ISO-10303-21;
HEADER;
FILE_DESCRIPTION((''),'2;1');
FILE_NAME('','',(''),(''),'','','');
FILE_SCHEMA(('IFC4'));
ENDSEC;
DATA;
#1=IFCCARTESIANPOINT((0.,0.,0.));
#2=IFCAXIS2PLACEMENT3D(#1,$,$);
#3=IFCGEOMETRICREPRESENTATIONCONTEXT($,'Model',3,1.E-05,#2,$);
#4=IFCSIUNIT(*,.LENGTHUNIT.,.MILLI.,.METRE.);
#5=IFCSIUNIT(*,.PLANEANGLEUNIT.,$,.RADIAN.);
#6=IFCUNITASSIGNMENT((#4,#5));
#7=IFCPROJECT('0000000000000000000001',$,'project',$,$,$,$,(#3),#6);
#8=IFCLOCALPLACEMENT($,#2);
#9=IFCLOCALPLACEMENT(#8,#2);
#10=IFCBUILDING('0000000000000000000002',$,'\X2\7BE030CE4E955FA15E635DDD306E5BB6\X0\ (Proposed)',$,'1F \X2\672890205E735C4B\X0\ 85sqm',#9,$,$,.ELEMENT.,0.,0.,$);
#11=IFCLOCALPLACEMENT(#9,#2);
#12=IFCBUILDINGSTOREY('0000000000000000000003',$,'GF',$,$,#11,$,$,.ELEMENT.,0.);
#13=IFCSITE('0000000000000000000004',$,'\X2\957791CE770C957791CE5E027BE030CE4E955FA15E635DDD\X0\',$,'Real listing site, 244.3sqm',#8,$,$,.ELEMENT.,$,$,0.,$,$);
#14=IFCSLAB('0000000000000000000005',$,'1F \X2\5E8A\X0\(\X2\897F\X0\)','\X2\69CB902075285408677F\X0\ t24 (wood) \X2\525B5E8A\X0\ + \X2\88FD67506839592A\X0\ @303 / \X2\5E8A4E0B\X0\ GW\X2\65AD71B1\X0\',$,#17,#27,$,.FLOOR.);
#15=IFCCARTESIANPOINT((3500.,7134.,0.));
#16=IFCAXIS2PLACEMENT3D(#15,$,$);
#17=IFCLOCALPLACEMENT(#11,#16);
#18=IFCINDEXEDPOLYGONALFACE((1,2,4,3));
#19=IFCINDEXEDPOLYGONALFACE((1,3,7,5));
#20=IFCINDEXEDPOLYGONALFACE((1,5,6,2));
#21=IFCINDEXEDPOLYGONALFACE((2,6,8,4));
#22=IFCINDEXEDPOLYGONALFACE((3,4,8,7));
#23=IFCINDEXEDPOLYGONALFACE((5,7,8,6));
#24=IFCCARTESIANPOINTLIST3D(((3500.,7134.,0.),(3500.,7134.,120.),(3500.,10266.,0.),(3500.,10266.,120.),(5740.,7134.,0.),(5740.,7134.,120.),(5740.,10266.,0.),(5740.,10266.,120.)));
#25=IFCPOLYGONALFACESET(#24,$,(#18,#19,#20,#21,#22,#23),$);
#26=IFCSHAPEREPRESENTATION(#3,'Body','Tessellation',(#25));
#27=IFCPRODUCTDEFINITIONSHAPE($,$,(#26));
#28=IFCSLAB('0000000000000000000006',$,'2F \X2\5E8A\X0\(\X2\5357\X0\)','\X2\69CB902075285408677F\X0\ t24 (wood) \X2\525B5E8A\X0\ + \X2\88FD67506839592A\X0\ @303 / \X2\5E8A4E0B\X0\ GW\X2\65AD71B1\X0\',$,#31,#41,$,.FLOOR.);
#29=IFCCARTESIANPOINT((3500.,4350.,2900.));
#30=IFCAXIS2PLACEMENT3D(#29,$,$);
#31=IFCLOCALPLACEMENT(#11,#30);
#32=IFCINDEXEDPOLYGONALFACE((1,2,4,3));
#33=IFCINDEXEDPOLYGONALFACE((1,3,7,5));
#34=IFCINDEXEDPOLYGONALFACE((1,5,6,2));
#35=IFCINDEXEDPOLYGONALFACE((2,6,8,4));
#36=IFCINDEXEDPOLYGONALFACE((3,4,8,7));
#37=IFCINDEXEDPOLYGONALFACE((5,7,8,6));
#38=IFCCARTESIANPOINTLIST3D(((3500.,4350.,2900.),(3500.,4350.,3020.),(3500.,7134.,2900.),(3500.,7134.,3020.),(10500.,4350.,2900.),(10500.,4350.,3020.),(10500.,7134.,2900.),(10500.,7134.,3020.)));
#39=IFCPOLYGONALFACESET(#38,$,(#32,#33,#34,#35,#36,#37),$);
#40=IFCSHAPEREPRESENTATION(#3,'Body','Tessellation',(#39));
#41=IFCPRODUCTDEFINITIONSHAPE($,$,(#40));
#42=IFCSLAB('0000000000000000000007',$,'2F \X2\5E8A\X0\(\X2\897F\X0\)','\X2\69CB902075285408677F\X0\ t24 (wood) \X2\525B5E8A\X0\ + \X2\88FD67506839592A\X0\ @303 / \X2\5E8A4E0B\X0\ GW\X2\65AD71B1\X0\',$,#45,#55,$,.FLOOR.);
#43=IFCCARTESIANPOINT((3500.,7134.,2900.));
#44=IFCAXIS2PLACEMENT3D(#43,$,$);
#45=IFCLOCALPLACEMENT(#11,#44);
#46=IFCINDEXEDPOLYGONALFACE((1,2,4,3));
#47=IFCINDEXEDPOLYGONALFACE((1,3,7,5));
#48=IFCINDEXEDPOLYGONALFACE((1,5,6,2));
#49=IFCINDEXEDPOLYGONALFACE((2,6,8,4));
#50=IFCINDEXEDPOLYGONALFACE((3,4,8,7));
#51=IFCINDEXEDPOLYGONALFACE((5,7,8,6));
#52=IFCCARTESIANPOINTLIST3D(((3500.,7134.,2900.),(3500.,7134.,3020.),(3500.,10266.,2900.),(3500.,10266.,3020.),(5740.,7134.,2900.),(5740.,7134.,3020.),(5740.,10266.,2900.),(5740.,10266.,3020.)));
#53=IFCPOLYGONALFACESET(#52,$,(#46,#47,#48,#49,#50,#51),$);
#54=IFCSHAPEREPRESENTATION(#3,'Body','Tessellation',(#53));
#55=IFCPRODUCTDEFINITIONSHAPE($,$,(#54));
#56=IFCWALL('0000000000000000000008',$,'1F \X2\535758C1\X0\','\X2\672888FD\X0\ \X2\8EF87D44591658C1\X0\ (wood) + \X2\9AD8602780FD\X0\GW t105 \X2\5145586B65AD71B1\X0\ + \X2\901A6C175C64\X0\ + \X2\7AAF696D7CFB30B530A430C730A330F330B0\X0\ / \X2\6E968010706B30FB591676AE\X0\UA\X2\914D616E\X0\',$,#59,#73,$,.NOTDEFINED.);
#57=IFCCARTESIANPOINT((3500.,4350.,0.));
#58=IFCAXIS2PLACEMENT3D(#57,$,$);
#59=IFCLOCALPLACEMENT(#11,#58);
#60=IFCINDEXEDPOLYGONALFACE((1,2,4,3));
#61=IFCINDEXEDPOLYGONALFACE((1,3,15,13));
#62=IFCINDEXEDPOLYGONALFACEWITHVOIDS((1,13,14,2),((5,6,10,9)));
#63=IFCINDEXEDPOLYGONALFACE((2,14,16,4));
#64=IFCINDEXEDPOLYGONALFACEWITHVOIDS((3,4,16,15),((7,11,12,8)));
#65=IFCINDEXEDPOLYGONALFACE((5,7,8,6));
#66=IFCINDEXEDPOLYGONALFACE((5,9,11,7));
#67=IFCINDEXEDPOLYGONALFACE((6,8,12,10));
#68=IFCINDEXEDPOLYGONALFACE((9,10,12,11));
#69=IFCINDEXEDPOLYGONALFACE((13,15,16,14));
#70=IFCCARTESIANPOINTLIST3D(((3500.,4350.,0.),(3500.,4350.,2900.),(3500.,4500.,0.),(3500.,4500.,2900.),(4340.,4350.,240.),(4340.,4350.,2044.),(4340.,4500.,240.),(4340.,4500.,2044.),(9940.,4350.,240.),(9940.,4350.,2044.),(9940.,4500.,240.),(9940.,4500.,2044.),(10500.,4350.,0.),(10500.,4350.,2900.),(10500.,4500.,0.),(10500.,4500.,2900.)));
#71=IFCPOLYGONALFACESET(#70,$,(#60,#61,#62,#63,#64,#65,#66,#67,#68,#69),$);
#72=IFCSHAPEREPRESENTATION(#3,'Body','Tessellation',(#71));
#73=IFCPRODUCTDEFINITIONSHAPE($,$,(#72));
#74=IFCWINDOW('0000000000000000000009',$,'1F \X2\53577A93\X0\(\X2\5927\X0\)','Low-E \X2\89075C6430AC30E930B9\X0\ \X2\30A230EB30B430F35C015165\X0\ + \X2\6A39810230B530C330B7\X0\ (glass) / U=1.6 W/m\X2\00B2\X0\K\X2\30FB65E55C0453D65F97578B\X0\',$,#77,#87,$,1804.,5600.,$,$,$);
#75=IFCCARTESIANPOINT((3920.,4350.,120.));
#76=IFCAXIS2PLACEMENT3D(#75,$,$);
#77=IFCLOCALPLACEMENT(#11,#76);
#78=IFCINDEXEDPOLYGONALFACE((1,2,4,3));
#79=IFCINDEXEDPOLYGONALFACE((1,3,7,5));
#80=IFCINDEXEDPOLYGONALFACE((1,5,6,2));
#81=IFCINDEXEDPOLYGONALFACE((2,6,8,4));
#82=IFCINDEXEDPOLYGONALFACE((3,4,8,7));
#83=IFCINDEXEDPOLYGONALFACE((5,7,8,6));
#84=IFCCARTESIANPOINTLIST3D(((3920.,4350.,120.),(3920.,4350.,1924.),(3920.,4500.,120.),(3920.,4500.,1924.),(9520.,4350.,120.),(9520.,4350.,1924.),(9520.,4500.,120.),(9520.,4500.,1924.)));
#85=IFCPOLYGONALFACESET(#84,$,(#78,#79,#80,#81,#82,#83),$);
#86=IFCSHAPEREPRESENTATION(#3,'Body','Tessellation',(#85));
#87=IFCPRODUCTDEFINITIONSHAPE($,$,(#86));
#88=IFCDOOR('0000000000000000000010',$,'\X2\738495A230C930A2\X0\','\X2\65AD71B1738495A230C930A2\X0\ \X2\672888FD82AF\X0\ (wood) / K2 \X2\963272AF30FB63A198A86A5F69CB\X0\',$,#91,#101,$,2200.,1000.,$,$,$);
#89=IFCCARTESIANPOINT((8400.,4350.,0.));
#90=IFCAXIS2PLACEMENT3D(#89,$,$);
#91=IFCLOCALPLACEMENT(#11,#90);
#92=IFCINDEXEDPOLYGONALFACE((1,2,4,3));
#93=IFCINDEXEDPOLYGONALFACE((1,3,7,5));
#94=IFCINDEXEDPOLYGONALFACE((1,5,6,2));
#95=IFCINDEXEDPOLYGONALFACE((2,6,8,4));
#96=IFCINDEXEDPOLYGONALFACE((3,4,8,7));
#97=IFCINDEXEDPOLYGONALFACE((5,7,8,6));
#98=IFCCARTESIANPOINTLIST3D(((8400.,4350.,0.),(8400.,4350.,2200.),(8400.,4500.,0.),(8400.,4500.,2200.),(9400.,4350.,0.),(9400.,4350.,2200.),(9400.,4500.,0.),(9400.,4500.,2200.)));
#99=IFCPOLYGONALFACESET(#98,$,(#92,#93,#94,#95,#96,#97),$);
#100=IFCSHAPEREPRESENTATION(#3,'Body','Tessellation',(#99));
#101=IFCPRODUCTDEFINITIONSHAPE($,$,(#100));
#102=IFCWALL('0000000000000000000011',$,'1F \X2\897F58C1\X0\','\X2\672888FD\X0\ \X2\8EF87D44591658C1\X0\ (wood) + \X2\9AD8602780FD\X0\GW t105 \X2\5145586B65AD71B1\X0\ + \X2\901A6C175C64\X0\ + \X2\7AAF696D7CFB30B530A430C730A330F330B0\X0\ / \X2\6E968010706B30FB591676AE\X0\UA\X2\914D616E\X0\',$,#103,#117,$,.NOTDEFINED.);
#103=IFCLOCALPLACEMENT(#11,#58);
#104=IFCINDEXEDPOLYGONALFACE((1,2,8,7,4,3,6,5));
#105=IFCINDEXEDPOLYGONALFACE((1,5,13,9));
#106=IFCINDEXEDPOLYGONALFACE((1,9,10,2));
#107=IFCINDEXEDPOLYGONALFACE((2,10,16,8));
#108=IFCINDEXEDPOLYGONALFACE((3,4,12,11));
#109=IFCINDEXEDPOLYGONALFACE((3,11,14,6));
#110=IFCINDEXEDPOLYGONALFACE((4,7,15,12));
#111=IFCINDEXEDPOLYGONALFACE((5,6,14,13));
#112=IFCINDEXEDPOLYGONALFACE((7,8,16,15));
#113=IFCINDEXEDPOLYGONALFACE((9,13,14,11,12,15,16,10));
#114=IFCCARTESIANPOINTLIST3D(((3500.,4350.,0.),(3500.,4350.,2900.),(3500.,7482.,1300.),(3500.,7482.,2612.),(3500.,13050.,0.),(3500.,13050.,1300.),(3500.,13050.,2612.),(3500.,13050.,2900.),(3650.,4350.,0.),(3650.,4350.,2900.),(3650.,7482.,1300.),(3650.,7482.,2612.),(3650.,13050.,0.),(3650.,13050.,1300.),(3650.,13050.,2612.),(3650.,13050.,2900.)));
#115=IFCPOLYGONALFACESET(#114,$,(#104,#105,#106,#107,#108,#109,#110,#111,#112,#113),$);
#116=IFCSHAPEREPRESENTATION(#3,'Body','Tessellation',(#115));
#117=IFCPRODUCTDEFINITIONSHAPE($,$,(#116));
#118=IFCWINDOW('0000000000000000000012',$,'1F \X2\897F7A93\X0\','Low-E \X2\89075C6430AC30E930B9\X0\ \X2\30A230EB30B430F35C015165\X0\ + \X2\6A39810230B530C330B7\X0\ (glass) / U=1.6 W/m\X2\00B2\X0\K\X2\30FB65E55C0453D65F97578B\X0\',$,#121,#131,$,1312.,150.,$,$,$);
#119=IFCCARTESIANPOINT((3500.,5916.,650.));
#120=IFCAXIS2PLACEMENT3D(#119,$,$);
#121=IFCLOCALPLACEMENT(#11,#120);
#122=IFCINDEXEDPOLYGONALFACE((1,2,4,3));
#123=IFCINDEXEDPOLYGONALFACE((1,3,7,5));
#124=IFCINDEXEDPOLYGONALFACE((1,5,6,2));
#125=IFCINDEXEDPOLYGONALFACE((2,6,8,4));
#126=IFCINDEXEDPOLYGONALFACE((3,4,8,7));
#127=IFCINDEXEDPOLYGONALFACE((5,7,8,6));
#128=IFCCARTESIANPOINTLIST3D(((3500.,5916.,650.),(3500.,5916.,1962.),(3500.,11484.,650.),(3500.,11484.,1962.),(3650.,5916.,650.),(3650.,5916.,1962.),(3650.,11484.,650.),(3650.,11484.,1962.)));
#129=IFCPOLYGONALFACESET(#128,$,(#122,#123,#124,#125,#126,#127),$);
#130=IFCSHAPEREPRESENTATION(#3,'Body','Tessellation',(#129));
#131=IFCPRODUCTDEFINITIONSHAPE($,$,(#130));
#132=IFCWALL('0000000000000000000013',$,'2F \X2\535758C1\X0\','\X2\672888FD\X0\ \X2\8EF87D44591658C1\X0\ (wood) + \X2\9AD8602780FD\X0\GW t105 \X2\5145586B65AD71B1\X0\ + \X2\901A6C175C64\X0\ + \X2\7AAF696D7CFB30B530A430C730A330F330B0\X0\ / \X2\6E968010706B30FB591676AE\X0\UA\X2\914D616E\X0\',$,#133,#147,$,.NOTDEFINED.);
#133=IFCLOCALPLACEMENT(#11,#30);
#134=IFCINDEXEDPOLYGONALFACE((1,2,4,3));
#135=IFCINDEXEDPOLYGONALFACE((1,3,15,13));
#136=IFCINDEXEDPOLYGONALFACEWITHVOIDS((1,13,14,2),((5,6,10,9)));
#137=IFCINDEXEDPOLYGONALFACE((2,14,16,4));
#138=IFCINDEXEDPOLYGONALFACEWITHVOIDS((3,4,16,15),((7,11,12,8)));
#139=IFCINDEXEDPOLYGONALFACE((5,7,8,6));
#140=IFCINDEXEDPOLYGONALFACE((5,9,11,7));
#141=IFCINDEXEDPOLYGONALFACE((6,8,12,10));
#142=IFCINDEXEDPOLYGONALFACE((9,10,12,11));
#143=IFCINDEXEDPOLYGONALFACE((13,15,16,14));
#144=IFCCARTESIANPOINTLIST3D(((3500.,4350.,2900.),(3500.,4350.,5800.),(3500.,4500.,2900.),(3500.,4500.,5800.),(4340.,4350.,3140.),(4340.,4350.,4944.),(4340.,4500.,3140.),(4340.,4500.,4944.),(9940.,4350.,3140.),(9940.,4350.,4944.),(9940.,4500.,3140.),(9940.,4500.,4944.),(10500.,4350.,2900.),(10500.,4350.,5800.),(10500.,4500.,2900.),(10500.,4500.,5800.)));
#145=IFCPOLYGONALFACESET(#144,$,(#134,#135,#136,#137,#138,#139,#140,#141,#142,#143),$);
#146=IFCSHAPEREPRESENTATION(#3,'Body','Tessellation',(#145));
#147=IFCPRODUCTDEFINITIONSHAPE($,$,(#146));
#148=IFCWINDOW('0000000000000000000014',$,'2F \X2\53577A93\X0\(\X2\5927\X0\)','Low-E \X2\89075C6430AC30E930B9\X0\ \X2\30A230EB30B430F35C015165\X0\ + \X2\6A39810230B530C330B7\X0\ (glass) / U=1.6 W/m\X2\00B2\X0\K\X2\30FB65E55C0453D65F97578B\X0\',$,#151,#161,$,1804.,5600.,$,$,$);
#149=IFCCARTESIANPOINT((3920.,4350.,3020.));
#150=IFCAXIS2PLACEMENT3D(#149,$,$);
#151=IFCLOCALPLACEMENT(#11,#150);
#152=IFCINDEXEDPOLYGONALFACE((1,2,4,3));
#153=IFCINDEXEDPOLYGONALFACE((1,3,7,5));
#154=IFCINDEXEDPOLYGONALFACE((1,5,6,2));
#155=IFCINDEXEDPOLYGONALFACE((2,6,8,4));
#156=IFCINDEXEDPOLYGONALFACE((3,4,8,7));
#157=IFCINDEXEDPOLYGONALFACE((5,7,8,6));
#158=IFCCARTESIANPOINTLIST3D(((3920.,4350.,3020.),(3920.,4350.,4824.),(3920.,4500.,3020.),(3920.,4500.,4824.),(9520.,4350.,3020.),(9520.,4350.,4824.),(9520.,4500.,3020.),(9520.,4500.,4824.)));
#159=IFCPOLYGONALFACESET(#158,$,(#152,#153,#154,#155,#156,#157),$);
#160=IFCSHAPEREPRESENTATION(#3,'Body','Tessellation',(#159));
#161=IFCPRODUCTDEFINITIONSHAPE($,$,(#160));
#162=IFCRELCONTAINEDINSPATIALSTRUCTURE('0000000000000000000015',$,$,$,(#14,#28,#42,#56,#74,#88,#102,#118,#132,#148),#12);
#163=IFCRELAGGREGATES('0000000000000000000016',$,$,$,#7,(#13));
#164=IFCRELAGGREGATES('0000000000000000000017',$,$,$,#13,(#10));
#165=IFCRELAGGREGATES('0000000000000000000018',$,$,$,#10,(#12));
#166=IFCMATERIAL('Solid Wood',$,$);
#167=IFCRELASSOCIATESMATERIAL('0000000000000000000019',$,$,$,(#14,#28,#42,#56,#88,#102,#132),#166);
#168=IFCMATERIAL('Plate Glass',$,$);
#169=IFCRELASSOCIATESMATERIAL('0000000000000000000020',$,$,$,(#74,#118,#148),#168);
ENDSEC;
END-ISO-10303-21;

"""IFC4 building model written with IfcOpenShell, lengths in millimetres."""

from ifc_helpers import new_model, si_unit, frame, frame_2d, origin, place, context, project, spatial, rectangle, extrude, material, element, fill, save


model = new_model("IFC4")

# Units and contexts
model_context = context("Model", 3, precision=1e-05, world=origin())
ifc_project = project(units=[si_unit("LENGTHUNIT", "METRE", prefix="MILLI"), si_unit("PLANEANGLEUNIT", "RADIAN")], contexts=[model_context])

# Site, building, storey
site_placement = place(None, origin())
site = spatial("IfcSite", under=ifc_project, at=site_placement, Name="長野県長野市篠ノ井御幣川", ObjectType="Real listing site, 244.3sqm", CompositionType="ELEMENT", RefElevation=0.0)
building_placement = place(site_placement, origin())
building = spatial("IfcBuilding", under=site, at=building_placement, Name="篠ノ井御幣川の家 (Proposed)", ObjectType="1F 木造平屋 85sqm", CompositionType="ELEMENT", ElevationOfRefHeight=0.0, ElevationOfTerrain=0.0)
storey_placement = place(building_placement, origin())
storey = spatial("IfcBuildingStorey", under=building, at=storey_placement, Name="GF", CompositionType="ELEMENT", Elevation=0.0)

# Slabs
ifc_material_1 = material(Name="Solid Wood")
slab_1_placement = place(storey_placement, frame((3500.0, 7134.0, 0.0)))
element("IfcSlab", 1, at=slab_1_placement, inside=storey, material=ifc_material_1, Name="1F 床(西)", Description="構造用合板 t24 (wood) 剛床 + 製材根太 @303 / 床下 GW断熱", PredefinedType="FLOOR", context=model_context, shape_type="SweptSolid", body=[
    extrude(rectangle(XDim=2240.0, YDim=3132.0, at=frame_2d((1120.0, 1566.0))), frame((3500.0, 7134.0, 0.0)), (0.0, 0.0, 1.0), 120.0),
])
slab_2_placement = place(storey_placement, frame((3500.0, 4350.0, 2900.0)))
element("IfcSlab", 2, at=slab_2_placement, inside=storey, material=ifc_material_1, Name="2F 床(南)", Description="構造用合板 t24 (wood) 剛床 + 製材根太 @303 / 床下 GW断熱", PredefinedType="FLOOR", context=model_context, shape_type="SweptSolid", body=[
    extrude(rectangle(XDim=7000.0, YDim=2784.0, at=frame_2d((3500.0, 1392.0))), frame((3500.0, 4350.0, 2900.0)), (0.0, 0.0, 1.0), 120.0),
])
slab_3_placement = place(storey_placement, frame((3500.0, 7134.0, 2900.0)))
element("IfcSlab", 3, at=slab_3_placement, inside=storey, material=ifc_material_1, Name="2F 床(西)", Description="構造用合板 t24 (wood) 剛床 + 製材根太 @303 / 床下 GW断熱", PredefinedType="FLOOR", context=model_context, shape_type="SweptSolid", body=[
    extrude(rectangle(XDim=2240.0, YDim=3132.0, at=frame_2d((1120.0, 1566.0))), frame((3500.0, 7134.0, 2900.0)), (0.0, 0.0, 1.0), 120.0),
])

# Wall, openings, window, door
wall_1_placement = place(storey_placement, frame((3500.0, 4350.0, 0.0)))
wall_1 = element("IfcWall", 4, at=wall_1_placement, inside=storey, material=ifc_material_1, Name="1F 南壁", Description="木製 軸組外壁 (wood) + 高性能GW t105 充填断熱 + 通気層 + 窯業系サイディング / 準耐火・外皮UA配慮", PredefinedType="NOTDEFINED", context=model_context, shape_type="SweptSolid", body=[
    extrude(rectangle(XDim=7000.0, YDim=150.0, at=frame_2d((3500.0, 75.0))), frame((3500.0, 4350.0, 0.0)), (0.0, 0.0, 1.0), 2900.0),
])
opening_1_placement = place(storey_placement, frame((3920.0, 4350.0, 120.0)))
opening_1 = element("IfcOpeningElement", 5, at=opening_1_placement, cuts=wall_1, PredefinedType="NOTDEFINED", context=model_context, shape_type="SweptSolid", body=[
    extrude(rectangle(XDim=5600.0, YDim=150.0, at=frame_2d((2800.0, 75.0))), frame((3920.0, 4350.0, 120.0)), (0.0, 0.0, 1.0), 1804.0),
])
opening_2_placement = place(storey_placement, frame((8400.0, 4350.0, 0.0)))
opening_2 = element("IfcOpeningElement", 6, at=opening_2_placement, cuts=wall_1, PredefinedType="NOTDEFINED", context=model_context, shape_type="SweptSolid", body=[
    extrude(rectangle(XDim=1000.0, YDim=150.0, at=frame_2d((500.0, 75.0))), frame((8400.0, 4350.0, 0.0)), (0.0, 0.0, 1.0), 2200.0),
])
ifc_material_2 = material(Name="Plate Glass")
window_1_placement = place(storey_placement, frame((3920.0, 4350.0, 120.0)))
window_1 = element("IfcWindow", 7, at=window_1_placement, inside=storey, material=ifc_material_2, Name="1F 南窓(大)", Description="Low-E 複層ガラス アルゴン封入 + 樹脂サッシ (glass) / U=1.6 W/m²K・日射取得型", OverallHeight=1804.0, OverallWidth=5600.0, context=model_context, shape_type="SweptSolid", body=[
    extrude(rectangle(XDim=5600.0, YDim=150.0, at=frame_2d((2800.0, 75.0))), frame((3920.0, 4350.0, 120.0)), (0.0, 0.0, 1.0), 1804.0),
])
fill(opening_1, window_1)
door_placement = place(storey_placement, frame((8400.0, 4350.0, 0.0)))
door = element("IfcDoor", 8, at=door_placement, inside=storey, material=ifc_material_1, Name="玄関ドア", Description="断熱玄関ドア 木製芯 (wood) / K2 防犯・採風機構", OverallHeight=2200.0, OverallWidth=1000.0, context=model_context, shape_type="SweptSolid", body=[
    extrude(rectangle(XDim=1000.0, YDim=150.0, at=frame_2d((500.0, 75.0))), frame((8400.0, 4350.0, 0.0)), (0.0, 0.0, 1.0), 2200.0),
])
fill(opening_2, door)

# Walls, openings, windows
wall_2_placement = place(storey_placement, frame((3500.0, 4350.0, 0.0)))
wall_2 = element("IfcWall", 9, at=wall_2_placement, inside=storey, material=ifc_material_1, Name="1F 西壁", Description="木製 軸組外壁 (wood) + 高性能GW t105 充填断熱 + 通気層 + 窯業系サイディング / 準耐火・外皮UA配慮", PredefinedType="NOTDEFINED", context=model_context, shape_type="SweptSolid", body=[
    extrude(rectangle(XDim=150.0, YDim=8700.0, at=frame_2d((75.0, 4350.0))), frame((3500.0, 4350.0, 0.0)), (0.0, 0.0, 1.0), 2900.0),
])
opening_3_placement = place(storey_placement, frame((3500.0, 5916.0, 650.0)))
opening_3 = element("IfcOpeningElement", 10, at=opening_3_placement, cuts=wall_2, PredefinedType="NOTDEFINED", context=model_context, shape_type="SweptSolid", body=[
    extrude(rectangle(XDim=150.0, YDim=5568.0, at=frame_2d((75.0, 2784.0))), frame((3500.0, 5916.0, 650.0)), (0.0, 0.0, 1.0), 1312.0),
])
window_2_placement = place(storey_placement, frame((3500.0, 5916.0, 650.0)))
window_2 = element("IfcWindow", 11, at=window_2_placement, inside=storey, material=ifc_material_2, Name="1F 西窓", Description="Low-E 複層ガラス アルゴン封入 + 樹脂サッシ (glass) / U=1.6 W/m²K・日射取得型", OverallHeight=1312.0, OverallWidth=150.0, context=model_context, shape_type="SweptSolid", body=[
    extrude(rectangle(XDim=150.0, YDim=5568.0, at=frame_2d((75.0, 2784.0))), frame((3500.0, 5916.0, 650.0)), (0.0, 0.0, 1.0), 1312.0),
])
fill(opening_3, window_2)
wall_3_placement = place(storey_placement, frame((3500.0, 4350.0, 2900.0)))
wall_3 = element("IfcWall", 12, at=wall_3_placement, inside=storey, material=ifc_material_1, Name="2F 南壁", Description="木製 軸組外壁 (wood) + 高性能GW t105 充填断熱 + 通気層 + 窯業系サイディング / 準耐火・外皮UA配慮", PredefinedType="NOTDEFINED", context=model_context, shape_type="SweptSolid", body=[
    extrude(rectangle(XDim=7000.0, YDim=150.0, at=frame_2d((3500.0, 75.0))), frame((3500.0, 4350.0, 2900.0)), (0.0, 0.0, 1.0), 2900.0),
])
opening_4_placement = place(storey_placement, frame((3920.0, 4350.0, 3020.0)))
opening_4 = element("IfcOpeningElement", 13, at=opening_4_placement, cuts=wall_3, PredefinedType="NOTDEFINED", context=model_context, shape_type="SweptSolid", body=[
    extrude(rectangle(XDim=5600.0, YDim=150.0, at=frame_2d((2800.0, 75.0))), frame((3920.0, 4350.0, 3020.0)), (0.0, 0.0, 1.0), 1804.0),
])
window_3_placement = place(storey_placement, frame((3920.0, 4350.0, 3020.0)))
window_3 = element("IfcWindow", 14, at=window_3_placement, inside=storey, material=ifc_material_2, Name="2F 南窓(大)", Description="Low-E 複層ガラス アルゴン封入 + 樹脂サッシ (glass) / U=1.6 W/m²K・日射取得型", OverallHeight=1804.0, OverallWidth=5600.0, context=model_context, shape_type="SweptSolid", body=[
    extrude(rectangle(XDim=5600.0, YDim=150.0, at=frame_2d((2800.0, 75.0))), frame((3920.0, 4350.0, 3020.0)), (0.0, 0.0, 1.0), 1804.0),
])
fill(opening_4, window_3)

save(model, "model.ifc")
